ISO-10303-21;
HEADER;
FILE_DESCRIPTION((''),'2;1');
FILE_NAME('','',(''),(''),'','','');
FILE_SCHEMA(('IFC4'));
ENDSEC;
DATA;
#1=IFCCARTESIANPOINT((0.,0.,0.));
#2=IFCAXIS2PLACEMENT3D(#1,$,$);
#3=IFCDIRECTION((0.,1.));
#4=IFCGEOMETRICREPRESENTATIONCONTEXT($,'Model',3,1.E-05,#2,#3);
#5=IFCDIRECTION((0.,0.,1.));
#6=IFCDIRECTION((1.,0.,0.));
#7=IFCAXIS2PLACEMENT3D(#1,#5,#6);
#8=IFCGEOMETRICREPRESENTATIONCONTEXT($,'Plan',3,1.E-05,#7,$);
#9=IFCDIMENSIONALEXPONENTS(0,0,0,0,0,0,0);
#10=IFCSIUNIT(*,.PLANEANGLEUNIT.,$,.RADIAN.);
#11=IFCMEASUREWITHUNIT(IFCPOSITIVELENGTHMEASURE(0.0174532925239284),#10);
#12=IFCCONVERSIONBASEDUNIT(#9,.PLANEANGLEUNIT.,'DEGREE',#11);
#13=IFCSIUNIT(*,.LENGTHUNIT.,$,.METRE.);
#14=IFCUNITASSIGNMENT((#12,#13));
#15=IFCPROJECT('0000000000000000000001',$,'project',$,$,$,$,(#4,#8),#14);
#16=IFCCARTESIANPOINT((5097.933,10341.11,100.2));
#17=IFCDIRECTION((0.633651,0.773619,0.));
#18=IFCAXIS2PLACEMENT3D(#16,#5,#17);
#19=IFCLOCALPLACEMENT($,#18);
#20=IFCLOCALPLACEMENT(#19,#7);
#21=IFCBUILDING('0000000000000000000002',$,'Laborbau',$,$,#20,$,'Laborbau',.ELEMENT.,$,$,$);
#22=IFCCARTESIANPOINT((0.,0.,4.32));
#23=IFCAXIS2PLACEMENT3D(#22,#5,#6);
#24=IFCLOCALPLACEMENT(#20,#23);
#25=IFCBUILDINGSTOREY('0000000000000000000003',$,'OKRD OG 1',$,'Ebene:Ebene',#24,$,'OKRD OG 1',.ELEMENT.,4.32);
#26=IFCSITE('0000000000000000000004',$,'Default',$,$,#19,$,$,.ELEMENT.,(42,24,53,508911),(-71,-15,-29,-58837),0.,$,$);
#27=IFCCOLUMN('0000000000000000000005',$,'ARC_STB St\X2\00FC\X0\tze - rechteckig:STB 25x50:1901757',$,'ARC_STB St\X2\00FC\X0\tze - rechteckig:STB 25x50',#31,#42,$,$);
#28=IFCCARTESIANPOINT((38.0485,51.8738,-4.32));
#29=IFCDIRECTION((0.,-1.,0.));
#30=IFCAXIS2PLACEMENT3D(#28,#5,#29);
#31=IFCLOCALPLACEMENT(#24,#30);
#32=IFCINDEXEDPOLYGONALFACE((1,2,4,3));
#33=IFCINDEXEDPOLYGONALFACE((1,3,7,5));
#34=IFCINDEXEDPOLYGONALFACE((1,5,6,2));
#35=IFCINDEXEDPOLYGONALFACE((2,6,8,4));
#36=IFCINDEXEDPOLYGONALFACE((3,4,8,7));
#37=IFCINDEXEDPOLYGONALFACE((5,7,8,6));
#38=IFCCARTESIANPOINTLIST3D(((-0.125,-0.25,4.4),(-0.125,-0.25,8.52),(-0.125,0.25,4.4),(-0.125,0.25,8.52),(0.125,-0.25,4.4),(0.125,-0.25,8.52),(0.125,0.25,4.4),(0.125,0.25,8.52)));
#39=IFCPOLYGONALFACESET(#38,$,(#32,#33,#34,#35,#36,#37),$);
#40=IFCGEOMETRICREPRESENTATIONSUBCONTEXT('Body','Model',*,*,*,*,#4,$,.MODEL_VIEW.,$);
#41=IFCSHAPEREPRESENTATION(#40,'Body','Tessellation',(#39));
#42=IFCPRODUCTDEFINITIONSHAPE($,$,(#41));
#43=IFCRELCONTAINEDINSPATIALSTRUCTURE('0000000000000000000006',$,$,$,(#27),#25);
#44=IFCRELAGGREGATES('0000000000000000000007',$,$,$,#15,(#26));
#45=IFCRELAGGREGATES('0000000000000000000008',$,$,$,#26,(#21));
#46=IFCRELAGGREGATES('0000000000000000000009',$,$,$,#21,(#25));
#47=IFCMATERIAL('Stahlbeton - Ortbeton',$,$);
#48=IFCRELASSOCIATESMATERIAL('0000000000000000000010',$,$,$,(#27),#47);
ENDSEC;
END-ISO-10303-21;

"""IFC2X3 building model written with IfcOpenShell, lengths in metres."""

from ifc_helpers import new_model, entity, si_unit, converted_unit, direction, frame, origin, origin_with_axes, origin_2d_with_axis, place, context, subcontext, project, spatial, rectangle, extrude, source, transform, mapped, material, element, save


model = new_model("IFC2X3")

# Units and contexts
model_context = context("Model", 3, precision=1e-05, world=origin(), true_north=direction((0.0, 1.0)))
plan_context = context("Plan", 3, precision=1e-05, world=origin_with_axes())
body_context = subcontext(model_context, "Body", "Model", "MODEL_VIEW")
ifc_project = project(units=[converted_unit("PLANEANGLEUNIT", "DEGREE", entity("IfcPositiveLengthMeasure", 0.0174532925239284), si_unit("PLANEANGLEUNIT", "RADIAN"), dimensions=[0, 0, 0, 0, 0, 0, 0]), si_unit("LENGTHUNIT", "METRE")], contexts=[model_context, plan_context])

# Site, building, storey
site_placement = place(None, frame((5097.933, 10341.11, 100.2), z_axis=(0.0, 0.0, 1.0), x_axis=(0.633651, 0.773619, 0.0)))
site = spatial("IfcSite", under=ifc_project, at=site_placement, Name="Default", CompositionType="ELEMENT", RefLatitude=(42, 24, 53, 508911), RefLongitude=(-71, -15, -29, -58837), RefElevation=0.0)
building_placement = place(site_placement, origin_with_axes())
building = spatial("IfcBuilding", under=site, at=building_placement, Name="Laborbau", LongName="Laborbau", CompositionType="ELEMENT")
storey_placement = place(building_placement, frame((0.0, 0.0, 4.32), z_axis=(0.0, 0.0, 1.0), x_axis=(1.0, 0.0, 0.0)))
storey = spatial("IfcBuildingStorey", under=building, at=storey_placement, Name="OKRD OG 1", ObjectType="Ebene:Ebene", LongName="OKRD OG 1", CompositionType="ELEMENT", Elevation=4.32)

# Column
ifc_material_1 = material(Name="Stahlbeton - Ortbeton")
shared_shape = source(origin(), body_context, "Body", "SweptSolid", [
    extrude(rectangle(XDim=0.5, YDim=0.25, at=origin_2d_with_axis()), frame((0.0, 0.0, 4.4), z_axis=(0.0, 0.0, 1.0), x_axis=(0.0, -1.0, 0.0)), (0.0, 0.0, 1.0), 4.12),
])
column_placement = place(storey_placement, frame((38.0485, 51.8738, -4.32), z_axis=(0.0, 0.0, 1.0), x_axis=(0.0, -1.0, 0.0)))
element("IfcColumn", 1, at=column_placement, inside=storey, material=ifc_material_1, Name="ARC_STB Stütze - rechteckig:STB 25x50:1901757", ObjectType="ARC_STB Stütze - rechteckig:STB 25x50", context=body_context, shape_type="MappedRepresentation", body=[
    mapped(shared_shape, transform((0.0, 0.0, 0.0), scale=1.0)),
])

save(model, "model.ifc")
